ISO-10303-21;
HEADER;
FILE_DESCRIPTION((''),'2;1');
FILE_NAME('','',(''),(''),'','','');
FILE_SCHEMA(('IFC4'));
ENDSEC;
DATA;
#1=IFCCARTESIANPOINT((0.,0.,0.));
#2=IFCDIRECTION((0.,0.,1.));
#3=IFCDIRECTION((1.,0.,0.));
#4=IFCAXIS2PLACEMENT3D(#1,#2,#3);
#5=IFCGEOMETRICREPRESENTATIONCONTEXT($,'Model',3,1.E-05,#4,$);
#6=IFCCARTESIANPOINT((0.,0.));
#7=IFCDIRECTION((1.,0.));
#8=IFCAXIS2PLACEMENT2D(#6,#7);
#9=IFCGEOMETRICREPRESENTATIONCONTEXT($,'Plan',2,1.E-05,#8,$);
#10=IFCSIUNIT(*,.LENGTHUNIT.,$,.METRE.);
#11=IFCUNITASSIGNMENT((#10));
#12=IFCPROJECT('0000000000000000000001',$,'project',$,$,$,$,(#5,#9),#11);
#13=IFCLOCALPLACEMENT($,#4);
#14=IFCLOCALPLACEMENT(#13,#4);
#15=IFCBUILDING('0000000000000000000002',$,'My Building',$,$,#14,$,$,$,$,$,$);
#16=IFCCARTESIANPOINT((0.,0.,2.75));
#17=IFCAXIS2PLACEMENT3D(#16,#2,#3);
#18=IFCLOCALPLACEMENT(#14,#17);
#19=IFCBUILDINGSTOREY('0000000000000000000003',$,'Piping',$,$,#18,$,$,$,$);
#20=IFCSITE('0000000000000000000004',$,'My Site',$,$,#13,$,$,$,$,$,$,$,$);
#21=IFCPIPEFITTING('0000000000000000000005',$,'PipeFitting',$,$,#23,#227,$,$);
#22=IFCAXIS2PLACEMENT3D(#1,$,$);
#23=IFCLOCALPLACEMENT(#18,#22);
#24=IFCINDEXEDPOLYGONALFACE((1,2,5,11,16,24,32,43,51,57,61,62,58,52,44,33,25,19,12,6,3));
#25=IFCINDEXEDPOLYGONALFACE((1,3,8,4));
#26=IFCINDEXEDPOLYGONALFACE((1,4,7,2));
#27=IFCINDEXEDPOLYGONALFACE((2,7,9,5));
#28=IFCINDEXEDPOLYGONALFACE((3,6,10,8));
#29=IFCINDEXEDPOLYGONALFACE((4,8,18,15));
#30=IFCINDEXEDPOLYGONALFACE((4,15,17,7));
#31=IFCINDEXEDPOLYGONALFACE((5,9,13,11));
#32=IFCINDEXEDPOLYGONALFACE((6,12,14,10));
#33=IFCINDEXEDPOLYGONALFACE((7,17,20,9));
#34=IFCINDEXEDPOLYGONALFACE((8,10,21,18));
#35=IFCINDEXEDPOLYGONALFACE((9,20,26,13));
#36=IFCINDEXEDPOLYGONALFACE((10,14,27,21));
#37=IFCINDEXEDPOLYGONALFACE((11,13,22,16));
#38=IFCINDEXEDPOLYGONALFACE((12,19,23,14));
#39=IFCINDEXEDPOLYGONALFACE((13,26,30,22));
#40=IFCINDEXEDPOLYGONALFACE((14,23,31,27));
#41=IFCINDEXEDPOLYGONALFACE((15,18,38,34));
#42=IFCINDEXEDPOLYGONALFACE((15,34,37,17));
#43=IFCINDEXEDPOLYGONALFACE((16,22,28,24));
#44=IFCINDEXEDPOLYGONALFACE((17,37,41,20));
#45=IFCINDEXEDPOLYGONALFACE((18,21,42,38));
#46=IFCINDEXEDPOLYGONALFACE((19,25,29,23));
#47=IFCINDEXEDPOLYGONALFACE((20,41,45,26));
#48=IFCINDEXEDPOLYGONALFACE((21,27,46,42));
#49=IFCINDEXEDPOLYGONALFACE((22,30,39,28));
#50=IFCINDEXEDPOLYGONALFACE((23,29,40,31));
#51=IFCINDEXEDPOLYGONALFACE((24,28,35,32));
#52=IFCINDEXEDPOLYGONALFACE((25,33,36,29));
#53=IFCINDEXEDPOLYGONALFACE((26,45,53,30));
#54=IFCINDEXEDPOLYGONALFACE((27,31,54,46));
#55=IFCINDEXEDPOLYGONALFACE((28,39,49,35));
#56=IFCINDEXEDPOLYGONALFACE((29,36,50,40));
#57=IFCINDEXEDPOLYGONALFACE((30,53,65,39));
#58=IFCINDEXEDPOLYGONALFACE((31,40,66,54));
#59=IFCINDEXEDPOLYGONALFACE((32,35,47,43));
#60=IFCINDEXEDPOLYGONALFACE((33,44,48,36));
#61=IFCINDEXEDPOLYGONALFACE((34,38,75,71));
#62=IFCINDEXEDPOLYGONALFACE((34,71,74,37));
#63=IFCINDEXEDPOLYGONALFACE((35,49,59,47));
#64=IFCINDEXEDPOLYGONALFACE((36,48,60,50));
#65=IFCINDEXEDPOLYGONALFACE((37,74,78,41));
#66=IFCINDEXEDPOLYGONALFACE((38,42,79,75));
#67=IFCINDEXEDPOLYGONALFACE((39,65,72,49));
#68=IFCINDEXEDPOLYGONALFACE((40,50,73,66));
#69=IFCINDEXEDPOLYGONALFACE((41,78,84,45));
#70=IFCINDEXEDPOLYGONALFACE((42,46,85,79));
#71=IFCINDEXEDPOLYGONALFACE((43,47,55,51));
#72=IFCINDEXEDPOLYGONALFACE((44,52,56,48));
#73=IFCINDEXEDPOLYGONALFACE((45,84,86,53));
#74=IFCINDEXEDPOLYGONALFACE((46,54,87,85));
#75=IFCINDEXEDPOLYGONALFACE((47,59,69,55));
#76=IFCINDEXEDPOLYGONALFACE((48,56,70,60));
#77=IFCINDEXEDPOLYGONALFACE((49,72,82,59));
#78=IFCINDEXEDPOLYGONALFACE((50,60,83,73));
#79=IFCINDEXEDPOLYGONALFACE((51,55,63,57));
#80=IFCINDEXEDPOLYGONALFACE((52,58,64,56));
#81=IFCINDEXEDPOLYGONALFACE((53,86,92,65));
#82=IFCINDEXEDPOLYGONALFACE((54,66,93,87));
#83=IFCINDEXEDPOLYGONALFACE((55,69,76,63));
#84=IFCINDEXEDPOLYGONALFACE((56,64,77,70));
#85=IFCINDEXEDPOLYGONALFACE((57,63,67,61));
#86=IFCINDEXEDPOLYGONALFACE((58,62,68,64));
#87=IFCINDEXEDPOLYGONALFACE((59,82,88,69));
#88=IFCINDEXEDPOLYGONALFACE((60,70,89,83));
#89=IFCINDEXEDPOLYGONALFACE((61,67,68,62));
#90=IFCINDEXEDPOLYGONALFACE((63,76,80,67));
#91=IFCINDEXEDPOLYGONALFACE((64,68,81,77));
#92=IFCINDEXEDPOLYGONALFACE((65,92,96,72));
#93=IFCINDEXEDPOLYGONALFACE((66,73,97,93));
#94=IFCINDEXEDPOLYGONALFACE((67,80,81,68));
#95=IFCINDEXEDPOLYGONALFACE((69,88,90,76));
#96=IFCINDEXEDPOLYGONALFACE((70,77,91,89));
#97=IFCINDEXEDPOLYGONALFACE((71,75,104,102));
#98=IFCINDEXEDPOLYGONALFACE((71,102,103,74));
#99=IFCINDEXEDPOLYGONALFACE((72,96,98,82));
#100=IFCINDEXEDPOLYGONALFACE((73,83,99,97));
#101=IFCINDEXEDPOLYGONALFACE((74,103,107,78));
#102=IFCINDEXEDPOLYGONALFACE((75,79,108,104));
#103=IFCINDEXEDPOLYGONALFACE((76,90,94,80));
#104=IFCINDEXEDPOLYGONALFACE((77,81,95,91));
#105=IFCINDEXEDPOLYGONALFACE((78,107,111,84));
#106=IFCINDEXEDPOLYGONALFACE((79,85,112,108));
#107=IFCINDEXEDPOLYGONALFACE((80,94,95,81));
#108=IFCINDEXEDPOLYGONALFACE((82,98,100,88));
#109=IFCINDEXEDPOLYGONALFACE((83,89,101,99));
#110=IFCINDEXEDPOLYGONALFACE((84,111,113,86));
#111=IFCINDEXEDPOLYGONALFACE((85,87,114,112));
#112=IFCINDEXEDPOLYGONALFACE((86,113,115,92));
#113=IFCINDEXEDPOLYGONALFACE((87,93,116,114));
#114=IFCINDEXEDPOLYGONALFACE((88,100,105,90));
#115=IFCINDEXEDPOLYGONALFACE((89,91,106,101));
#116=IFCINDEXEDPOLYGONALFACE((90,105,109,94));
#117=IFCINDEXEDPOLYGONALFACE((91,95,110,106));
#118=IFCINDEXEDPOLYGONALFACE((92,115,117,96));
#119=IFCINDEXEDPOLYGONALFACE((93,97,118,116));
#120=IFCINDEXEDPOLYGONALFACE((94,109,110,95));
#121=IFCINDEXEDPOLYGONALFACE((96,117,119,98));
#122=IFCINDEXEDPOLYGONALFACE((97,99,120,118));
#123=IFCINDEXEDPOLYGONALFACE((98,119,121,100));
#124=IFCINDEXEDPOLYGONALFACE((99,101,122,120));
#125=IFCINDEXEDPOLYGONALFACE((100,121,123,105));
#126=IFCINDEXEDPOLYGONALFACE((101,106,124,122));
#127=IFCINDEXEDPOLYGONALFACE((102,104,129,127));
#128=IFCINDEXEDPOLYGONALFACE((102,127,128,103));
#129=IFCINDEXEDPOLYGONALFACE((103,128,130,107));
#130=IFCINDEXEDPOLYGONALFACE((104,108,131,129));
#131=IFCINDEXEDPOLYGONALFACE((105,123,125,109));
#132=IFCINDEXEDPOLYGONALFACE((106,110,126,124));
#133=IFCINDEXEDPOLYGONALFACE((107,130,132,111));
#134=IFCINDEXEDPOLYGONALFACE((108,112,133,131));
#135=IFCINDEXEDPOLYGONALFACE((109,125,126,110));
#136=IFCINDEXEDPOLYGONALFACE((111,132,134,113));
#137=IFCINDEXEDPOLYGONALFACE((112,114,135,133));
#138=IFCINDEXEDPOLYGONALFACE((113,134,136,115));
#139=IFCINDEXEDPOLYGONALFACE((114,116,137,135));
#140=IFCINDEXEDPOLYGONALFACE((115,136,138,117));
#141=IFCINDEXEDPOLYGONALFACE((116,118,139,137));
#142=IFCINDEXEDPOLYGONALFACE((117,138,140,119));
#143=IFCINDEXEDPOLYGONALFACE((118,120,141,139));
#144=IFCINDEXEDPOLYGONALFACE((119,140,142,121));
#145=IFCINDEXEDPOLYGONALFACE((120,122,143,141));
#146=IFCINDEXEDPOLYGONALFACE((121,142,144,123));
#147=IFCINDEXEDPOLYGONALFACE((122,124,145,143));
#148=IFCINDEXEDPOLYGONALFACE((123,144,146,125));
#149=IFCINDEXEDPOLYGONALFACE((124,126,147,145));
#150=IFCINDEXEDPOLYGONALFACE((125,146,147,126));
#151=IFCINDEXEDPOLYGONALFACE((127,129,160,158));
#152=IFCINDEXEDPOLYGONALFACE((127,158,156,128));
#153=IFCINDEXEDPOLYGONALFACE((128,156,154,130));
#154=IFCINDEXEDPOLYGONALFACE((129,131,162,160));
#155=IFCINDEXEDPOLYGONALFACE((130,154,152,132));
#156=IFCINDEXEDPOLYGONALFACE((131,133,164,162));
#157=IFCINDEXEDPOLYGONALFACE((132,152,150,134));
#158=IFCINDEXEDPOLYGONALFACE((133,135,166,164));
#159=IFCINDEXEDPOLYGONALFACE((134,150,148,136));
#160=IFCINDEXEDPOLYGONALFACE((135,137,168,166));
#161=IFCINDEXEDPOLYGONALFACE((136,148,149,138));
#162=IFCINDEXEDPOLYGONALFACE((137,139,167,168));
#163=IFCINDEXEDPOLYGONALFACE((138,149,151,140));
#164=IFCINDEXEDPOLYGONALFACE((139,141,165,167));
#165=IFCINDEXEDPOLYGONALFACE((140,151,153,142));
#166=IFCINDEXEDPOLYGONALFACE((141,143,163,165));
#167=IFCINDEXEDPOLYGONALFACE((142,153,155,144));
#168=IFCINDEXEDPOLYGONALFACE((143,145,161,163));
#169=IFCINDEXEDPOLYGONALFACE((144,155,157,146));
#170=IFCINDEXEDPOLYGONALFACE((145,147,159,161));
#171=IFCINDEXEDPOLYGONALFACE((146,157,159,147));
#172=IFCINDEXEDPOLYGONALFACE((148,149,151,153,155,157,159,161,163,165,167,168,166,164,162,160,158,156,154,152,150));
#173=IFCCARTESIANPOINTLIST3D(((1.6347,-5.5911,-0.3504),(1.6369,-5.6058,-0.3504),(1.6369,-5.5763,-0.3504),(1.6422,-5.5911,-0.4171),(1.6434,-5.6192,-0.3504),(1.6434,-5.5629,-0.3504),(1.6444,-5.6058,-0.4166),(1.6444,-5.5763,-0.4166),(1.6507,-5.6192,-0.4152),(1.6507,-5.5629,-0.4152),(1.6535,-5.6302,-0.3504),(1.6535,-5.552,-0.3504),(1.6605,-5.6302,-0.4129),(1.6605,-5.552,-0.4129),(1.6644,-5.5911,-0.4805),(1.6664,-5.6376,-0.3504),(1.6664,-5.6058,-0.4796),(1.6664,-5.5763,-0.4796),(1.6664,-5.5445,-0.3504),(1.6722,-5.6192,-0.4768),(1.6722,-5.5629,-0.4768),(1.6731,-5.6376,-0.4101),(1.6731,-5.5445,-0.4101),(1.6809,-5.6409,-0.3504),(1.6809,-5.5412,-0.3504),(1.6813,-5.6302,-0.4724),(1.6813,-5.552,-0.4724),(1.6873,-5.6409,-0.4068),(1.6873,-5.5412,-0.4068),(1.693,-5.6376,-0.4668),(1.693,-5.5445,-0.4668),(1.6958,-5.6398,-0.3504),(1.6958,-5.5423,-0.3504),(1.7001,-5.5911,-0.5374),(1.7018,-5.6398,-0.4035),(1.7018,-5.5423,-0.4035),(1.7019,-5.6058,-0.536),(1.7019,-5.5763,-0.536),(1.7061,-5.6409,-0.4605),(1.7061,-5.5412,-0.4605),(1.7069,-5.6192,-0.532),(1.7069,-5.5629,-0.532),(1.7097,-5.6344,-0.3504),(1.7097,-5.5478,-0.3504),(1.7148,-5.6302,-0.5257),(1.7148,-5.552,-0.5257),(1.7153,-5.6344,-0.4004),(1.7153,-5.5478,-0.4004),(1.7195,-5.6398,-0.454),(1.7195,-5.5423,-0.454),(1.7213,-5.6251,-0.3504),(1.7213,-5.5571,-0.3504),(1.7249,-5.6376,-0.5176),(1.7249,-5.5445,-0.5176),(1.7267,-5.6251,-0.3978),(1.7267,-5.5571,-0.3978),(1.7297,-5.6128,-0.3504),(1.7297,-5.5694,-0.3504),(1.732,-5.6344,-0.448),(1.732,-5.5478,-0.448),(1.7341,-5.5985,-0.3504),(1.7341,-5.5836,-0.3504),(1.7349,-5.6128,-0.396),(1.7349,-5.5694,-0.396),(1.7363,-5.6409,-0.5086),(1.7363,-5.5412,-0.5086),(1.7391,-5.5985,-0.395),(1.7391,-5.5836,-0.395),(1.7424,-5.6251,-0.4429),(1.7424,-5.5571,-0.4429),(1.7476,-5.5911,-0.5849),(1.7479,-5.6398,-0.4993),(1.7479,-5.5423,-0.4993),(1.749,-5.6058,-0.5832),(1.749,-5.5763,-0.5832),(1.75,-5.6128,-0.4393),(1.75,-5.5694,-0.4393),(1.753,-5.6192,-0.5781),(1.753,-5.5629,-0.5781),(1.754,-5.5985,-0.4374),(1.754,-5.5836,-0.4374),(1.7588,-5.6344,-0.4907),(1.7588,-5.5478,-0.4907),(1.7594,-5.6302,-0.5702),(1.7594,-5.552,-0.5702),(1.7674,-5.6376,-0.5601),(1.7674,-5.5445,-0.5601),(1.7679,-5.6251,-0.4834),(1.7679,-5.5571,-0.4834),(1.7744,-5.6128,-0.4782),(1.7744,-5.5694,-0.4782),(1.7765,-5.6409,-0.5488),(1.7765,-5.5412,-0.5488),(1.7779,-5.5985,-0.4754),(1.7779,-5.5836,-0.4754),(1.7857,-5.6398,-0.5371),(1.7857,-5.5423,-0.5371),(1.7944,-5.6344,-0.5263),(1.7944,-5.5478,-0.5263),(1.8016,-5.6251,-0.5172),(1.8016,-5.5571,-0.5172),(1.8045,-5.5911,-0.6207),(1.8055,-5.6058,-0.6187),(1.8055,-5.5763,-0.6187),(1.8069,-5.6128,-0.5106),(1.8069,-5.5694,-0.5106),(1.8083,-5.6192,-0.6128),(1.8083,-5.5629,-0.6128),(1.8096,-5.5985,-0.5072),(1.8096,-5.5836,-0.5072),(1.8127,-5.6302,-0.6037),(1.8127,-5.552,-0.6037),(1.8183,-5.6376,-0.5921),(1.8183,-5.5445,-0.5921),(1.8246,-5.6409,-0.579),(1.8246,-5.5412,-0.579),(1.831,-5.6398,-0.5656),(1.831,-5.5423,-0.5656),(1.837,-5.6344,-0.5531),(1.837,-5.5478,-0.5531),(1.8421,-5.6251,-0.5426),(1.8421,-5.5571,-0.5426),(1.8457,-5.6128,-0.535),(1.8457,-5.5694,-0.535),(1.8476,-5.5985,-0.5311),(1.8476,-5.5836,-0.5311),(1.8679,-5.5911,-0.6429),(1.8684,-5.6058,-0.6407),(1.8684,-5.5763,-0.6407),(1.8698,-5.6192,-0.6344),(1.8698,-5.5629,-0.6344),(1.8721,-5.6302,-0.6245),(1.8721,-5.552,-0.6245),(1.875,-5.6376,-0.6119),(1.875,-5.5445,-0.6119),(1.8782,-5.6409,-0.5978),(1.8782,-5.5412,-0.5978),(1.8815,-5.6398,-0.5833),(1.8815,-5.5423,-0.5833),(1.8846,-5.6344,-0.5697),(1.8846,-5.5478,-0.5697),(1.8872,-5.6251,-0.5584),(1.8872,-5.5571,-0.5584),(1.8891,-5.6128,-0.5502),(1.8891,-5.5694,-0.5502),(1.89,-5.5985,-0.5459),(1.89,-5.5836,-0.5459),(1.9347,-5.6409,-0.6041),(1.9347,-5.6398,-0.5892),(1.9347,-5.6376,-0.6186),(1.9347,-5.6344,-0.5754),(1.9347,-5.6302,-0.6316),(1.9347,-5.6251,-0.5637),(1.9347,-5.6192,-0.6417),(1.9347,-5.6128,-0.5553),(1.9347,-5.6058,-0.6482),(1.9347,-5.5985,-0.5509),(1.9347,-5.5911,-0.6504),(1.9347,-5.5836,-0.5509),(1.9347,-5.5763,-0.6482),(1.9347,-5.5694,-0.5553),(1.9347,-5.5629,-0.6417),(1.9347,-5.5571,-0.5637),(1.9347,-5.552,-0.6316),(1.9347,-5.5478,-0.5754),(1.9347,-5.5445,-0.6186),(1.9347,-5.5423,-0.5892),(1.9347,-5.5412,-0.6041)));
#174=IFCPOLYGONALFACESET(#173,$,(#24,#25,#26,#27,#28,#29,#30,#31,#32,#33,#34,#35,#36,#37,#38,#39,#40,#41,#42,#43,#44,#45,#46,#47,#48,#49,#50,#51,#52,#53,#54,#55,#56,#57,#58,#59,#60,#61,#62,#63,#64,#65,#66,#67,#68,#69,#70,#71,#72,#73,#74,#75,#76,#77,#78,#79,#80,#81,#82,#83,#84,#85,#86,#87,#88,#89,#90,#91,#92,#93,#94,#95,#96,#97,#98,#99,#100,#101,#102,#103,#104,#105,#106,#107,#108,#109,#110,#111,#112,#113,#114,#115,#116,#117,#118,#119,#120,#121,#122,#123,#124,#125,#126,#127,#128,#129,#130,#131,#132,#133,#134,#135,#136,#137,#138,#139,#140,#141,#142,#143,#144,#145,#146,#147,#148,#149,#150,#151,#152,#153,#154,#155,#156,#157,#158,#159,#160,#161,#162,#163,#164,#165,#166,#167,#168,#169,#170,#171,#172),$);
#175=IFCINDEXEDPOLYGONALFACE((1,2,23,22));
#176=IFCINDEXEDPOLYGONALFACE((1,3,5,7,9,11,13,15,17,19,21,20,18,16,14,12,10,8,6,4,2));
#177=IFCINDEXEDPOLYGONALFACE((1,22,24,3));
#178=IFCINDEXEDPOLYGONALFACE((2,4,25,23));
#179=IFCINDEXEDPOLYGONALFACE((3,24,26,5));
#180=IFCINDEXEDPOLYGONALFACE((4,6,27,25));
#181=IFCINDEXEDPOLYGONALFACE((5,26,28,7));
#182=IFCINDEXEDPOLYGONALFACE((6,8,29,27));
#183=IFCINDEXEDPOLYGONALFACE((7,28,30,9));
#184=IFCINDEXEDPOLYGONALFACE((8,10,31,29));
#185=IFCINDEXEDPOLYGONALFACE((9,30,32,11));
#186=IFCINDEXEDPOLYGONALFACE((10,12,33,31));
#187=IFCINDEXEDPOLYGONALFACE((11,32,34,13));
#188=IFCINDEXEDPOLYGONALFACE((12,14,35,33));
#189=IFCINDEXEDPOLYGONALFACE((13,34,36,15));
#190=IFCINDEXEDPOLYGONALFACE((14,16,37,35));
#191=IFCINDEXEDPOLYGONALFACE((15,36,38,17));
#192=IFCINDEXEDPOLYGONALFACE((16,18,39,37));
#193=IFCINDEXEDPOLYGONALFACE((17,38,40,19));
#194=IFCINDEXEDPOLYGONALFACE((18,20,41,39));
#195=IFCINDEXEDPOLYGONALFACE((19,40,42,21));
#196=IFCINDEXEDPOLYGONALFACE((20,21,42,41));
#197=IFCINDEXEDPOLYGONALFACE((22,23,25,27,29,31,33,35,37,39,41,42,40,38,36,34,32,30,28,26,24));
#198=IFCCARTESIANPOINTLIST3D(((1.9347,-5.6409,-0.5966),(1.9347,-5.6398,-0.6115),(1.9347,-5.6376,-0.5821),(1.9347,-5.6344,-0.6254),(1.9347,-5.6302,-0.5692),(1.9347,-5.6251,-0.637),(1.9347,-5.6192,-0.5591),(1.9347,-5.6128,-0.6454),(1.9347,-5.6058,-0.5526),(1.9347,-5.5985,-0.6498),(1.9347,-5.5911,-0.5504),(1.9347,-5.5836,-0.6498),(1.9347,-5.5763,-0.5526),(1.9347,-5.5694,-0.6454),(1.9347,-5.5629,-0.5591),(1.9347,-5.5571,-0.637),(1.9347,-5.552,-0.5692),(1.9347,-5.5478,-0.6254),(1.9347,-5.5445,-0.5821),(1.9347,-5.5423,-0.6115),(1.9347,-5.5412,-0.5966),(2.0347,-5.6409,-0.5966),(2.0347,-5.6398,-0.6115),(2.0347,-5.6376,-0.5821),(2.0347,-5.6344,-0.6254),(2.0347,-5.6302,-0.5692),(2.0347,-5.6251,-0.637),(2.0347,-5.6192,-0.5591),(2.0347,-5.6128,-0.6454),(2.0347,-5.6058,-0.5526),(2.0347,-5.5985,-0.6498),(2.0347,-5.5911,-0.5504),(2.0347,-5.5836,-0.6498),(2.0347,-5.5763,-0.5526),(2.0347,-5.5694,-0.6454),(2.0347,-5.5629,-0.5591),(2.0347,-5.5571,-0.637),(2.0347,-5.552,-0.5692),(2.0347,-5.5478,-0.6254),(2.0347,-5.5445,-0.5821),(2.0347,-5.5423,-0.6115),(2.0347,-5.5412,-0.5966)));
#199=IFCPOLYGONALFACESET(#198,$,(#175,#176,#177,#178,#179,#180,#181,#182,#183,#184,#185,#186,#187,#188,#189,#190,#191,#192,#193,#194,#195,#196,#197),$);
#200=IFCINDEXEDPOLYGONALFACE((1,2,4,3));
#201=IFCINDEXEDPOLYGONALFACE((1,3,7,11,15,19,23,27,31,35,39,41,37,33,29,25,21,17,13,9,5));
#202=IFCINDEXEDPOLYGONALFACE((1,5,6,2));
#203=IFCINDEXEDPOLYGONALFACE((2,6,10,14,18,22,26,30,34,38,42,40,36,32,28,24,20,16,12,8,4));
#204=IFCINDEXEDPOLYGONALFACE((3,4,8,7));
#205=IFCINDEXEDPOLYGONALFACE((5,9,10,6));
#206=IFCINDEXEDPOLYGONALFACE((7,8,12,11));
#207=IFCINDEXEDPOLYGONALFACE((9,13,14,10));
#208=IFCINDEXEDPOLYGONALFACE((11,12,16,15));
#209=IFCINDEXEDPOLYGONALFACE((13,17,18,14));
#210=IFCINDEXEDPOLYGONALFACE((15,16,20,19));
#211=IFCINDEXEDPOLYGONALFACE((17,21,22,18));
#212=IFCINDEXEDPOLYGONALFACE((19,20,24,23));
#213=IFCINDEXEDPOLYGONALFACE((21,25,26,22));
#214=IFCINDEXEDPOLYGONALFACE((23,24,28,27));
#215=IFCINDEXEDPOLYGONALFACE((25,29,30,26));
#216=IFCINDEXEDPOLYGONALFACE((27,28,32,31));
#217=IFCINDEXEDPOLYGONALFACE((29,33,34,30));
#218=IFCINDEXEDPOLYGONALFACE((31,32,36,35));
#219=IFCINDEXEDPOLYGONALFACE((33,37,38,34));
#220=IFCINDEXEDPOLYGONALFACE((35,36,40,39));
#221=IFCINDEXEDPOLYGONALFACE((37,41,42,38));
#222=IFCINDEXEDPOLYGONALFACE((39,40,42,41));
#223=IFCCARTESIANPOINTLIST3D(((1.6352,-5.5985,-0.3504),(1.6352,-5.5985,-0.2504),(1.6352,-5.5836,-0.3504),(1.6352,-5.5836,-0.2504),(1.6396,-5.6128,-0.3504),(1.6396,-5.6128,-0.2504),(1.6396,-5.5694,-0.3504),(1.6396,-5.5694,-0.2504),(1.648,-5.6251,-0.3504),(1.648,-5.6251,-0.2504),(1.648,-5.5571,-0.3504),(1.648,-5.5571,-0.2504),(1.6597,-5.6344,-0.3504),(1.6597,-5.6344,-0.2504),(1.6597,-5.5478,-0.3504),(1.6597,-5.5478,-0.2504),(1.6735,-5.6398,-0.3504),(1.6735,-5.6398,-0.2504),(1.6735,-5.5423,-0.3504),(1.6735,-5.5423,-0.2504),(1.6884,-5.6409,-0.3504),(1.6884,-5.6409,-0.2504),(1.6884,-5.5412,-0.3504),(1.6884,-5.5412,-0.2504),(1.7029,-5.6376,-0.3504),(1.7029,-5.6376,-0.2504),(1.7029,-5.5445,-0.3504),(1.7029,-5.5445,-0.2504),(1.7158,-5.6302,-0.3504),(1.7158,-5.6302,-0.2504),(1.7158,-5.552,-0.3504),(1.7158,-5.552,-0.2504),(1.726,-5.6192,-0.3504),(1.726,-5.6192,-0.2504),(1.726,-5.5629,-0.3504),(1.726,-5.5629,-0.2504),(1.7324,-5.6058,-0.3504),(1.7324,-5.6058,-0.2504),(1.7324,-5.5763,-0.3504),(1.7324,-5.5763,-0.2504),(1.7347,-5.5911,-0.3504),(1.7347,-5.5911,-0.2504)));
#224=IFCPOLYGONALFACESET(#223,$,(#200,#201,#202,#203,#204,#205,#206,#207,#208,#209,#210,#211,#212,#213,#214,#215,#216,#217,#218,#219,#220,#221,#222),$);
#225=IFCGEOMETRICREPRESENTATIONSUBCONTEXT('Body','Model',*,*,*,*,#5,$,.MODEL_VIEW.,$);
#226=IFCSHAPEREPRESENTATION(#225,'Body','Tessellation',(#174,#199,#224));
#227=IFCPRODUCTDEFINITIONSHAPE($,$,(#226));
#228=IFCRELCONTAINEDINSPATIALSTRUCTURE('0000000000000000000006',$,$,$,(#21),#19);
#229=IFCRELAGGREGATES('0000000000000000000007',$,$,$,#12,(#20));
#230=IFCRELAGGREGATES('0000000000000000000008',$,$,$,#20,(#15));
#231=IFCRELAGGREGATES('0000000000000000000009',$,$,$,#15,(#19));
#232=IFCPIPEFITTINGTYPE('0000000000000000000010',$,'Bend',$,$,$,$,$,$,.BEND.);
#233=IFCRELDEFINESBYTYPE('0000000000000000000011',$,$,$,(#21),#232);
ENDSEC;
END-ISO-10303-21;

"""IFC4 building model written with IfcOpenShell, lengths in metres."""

from ifc_helpers import new_model, entity, si_unit, frame, origin_with_axes, origin_2d_with_axis, place, context, subcontext, project, spatial, circle, extrude, source, transform, mapped, type_object, type_shapes, element, save


model = new_model("IFC4")

# Units and contexts
model_context = context("Model", 3, precision=1e-05, world=origin_with_axes())
plan_context = context("Plan", 2, precision=1e-05, world=origin_2d_with_axis())
body_context = subcontext(model_context, "Body", "Model", "MODEL_VIEW")
ifc_project = project(units=[si_unit("LENGTHUNIT", "METRE")], contexts=[model_context, plan_context])

# Site, building, storey
site_placement = place(None, origin_with_axes())
site = spatial("IfcSite", under=ifc_project, at=site_placement, Name="My Site")
building_placement = place(site_placement, origin_with_axes())
building = spatial("IfcBuilding", under=site, at=building_placement, Name="My Building")
storey_placement = place(building_placement, frame((0.0, 0.0, 2.75), z_axis=(0.0, 0.0, 1.0), x_axis=(1.0, 0.0, 0.0)))
storey = spatial("IfcBuildingStorey", under=building, at=storey_placement, Name="Piping")

# Pipe fitting
pipe_fitting_type = type_object("IfcPipeFittingType", Name="Bend", PredefinedType="BEND")
shared_shape = source(origin_with_axes(), body_context, "Body", "SolidModel", [
    entity("IfcSweptDiskSolid", entity("IfcIndexedPolyCurve", entity("IfcCartesianPointList3D", [[0.0, 0.0, -0.1], [0.0732, 0.0, -0.2768], [0.25, 0.0, -0.35]]), [entity("IfcArcIndex", [1, 2, 3])]), 0.05),
    extrude(circle(Radius=0.05), origin_with_axes(), (0.0, 0.0, -1.0), 0.1),
    extrude(circle(Radius=0.05), frame((0.25, 0.0, -0.35), z_axis=(1.0, 0.0, 0.0), x_axis=(0.0, 0.0, 1.0)), (0.0, 0.0, 1.0), 0.1),
])
type_shapes(pipe_fitting_type, [shared_shape])
for number, where, z_axis, x_axis, name in (
    (1, (2.0347, -5.5911, -0.6004), (1.0, 0.0, 0.0), (0.0, 0.0, 1.0), "PipeFitting"),
):
    element("IfcPipeFitting", number, at=place(storey_placement, frame(where, z_axis=z_axis, x_axis=x_axis)), inside=storey, type_object=pipe_fitting_type, Name=name, context=body_context, shape_type="MappedRepresentation", body=[
        mapped(shared_shape, transform((0.0, 0.0, 0.0), x_axis=(1.0, 0.0, 0.0), y_axis=(0.0, 1.0, 0.0), z_axis=(0.0, 0.0, 1.0), scale=1.0)),
    ])

save(model, "model.ifc")
